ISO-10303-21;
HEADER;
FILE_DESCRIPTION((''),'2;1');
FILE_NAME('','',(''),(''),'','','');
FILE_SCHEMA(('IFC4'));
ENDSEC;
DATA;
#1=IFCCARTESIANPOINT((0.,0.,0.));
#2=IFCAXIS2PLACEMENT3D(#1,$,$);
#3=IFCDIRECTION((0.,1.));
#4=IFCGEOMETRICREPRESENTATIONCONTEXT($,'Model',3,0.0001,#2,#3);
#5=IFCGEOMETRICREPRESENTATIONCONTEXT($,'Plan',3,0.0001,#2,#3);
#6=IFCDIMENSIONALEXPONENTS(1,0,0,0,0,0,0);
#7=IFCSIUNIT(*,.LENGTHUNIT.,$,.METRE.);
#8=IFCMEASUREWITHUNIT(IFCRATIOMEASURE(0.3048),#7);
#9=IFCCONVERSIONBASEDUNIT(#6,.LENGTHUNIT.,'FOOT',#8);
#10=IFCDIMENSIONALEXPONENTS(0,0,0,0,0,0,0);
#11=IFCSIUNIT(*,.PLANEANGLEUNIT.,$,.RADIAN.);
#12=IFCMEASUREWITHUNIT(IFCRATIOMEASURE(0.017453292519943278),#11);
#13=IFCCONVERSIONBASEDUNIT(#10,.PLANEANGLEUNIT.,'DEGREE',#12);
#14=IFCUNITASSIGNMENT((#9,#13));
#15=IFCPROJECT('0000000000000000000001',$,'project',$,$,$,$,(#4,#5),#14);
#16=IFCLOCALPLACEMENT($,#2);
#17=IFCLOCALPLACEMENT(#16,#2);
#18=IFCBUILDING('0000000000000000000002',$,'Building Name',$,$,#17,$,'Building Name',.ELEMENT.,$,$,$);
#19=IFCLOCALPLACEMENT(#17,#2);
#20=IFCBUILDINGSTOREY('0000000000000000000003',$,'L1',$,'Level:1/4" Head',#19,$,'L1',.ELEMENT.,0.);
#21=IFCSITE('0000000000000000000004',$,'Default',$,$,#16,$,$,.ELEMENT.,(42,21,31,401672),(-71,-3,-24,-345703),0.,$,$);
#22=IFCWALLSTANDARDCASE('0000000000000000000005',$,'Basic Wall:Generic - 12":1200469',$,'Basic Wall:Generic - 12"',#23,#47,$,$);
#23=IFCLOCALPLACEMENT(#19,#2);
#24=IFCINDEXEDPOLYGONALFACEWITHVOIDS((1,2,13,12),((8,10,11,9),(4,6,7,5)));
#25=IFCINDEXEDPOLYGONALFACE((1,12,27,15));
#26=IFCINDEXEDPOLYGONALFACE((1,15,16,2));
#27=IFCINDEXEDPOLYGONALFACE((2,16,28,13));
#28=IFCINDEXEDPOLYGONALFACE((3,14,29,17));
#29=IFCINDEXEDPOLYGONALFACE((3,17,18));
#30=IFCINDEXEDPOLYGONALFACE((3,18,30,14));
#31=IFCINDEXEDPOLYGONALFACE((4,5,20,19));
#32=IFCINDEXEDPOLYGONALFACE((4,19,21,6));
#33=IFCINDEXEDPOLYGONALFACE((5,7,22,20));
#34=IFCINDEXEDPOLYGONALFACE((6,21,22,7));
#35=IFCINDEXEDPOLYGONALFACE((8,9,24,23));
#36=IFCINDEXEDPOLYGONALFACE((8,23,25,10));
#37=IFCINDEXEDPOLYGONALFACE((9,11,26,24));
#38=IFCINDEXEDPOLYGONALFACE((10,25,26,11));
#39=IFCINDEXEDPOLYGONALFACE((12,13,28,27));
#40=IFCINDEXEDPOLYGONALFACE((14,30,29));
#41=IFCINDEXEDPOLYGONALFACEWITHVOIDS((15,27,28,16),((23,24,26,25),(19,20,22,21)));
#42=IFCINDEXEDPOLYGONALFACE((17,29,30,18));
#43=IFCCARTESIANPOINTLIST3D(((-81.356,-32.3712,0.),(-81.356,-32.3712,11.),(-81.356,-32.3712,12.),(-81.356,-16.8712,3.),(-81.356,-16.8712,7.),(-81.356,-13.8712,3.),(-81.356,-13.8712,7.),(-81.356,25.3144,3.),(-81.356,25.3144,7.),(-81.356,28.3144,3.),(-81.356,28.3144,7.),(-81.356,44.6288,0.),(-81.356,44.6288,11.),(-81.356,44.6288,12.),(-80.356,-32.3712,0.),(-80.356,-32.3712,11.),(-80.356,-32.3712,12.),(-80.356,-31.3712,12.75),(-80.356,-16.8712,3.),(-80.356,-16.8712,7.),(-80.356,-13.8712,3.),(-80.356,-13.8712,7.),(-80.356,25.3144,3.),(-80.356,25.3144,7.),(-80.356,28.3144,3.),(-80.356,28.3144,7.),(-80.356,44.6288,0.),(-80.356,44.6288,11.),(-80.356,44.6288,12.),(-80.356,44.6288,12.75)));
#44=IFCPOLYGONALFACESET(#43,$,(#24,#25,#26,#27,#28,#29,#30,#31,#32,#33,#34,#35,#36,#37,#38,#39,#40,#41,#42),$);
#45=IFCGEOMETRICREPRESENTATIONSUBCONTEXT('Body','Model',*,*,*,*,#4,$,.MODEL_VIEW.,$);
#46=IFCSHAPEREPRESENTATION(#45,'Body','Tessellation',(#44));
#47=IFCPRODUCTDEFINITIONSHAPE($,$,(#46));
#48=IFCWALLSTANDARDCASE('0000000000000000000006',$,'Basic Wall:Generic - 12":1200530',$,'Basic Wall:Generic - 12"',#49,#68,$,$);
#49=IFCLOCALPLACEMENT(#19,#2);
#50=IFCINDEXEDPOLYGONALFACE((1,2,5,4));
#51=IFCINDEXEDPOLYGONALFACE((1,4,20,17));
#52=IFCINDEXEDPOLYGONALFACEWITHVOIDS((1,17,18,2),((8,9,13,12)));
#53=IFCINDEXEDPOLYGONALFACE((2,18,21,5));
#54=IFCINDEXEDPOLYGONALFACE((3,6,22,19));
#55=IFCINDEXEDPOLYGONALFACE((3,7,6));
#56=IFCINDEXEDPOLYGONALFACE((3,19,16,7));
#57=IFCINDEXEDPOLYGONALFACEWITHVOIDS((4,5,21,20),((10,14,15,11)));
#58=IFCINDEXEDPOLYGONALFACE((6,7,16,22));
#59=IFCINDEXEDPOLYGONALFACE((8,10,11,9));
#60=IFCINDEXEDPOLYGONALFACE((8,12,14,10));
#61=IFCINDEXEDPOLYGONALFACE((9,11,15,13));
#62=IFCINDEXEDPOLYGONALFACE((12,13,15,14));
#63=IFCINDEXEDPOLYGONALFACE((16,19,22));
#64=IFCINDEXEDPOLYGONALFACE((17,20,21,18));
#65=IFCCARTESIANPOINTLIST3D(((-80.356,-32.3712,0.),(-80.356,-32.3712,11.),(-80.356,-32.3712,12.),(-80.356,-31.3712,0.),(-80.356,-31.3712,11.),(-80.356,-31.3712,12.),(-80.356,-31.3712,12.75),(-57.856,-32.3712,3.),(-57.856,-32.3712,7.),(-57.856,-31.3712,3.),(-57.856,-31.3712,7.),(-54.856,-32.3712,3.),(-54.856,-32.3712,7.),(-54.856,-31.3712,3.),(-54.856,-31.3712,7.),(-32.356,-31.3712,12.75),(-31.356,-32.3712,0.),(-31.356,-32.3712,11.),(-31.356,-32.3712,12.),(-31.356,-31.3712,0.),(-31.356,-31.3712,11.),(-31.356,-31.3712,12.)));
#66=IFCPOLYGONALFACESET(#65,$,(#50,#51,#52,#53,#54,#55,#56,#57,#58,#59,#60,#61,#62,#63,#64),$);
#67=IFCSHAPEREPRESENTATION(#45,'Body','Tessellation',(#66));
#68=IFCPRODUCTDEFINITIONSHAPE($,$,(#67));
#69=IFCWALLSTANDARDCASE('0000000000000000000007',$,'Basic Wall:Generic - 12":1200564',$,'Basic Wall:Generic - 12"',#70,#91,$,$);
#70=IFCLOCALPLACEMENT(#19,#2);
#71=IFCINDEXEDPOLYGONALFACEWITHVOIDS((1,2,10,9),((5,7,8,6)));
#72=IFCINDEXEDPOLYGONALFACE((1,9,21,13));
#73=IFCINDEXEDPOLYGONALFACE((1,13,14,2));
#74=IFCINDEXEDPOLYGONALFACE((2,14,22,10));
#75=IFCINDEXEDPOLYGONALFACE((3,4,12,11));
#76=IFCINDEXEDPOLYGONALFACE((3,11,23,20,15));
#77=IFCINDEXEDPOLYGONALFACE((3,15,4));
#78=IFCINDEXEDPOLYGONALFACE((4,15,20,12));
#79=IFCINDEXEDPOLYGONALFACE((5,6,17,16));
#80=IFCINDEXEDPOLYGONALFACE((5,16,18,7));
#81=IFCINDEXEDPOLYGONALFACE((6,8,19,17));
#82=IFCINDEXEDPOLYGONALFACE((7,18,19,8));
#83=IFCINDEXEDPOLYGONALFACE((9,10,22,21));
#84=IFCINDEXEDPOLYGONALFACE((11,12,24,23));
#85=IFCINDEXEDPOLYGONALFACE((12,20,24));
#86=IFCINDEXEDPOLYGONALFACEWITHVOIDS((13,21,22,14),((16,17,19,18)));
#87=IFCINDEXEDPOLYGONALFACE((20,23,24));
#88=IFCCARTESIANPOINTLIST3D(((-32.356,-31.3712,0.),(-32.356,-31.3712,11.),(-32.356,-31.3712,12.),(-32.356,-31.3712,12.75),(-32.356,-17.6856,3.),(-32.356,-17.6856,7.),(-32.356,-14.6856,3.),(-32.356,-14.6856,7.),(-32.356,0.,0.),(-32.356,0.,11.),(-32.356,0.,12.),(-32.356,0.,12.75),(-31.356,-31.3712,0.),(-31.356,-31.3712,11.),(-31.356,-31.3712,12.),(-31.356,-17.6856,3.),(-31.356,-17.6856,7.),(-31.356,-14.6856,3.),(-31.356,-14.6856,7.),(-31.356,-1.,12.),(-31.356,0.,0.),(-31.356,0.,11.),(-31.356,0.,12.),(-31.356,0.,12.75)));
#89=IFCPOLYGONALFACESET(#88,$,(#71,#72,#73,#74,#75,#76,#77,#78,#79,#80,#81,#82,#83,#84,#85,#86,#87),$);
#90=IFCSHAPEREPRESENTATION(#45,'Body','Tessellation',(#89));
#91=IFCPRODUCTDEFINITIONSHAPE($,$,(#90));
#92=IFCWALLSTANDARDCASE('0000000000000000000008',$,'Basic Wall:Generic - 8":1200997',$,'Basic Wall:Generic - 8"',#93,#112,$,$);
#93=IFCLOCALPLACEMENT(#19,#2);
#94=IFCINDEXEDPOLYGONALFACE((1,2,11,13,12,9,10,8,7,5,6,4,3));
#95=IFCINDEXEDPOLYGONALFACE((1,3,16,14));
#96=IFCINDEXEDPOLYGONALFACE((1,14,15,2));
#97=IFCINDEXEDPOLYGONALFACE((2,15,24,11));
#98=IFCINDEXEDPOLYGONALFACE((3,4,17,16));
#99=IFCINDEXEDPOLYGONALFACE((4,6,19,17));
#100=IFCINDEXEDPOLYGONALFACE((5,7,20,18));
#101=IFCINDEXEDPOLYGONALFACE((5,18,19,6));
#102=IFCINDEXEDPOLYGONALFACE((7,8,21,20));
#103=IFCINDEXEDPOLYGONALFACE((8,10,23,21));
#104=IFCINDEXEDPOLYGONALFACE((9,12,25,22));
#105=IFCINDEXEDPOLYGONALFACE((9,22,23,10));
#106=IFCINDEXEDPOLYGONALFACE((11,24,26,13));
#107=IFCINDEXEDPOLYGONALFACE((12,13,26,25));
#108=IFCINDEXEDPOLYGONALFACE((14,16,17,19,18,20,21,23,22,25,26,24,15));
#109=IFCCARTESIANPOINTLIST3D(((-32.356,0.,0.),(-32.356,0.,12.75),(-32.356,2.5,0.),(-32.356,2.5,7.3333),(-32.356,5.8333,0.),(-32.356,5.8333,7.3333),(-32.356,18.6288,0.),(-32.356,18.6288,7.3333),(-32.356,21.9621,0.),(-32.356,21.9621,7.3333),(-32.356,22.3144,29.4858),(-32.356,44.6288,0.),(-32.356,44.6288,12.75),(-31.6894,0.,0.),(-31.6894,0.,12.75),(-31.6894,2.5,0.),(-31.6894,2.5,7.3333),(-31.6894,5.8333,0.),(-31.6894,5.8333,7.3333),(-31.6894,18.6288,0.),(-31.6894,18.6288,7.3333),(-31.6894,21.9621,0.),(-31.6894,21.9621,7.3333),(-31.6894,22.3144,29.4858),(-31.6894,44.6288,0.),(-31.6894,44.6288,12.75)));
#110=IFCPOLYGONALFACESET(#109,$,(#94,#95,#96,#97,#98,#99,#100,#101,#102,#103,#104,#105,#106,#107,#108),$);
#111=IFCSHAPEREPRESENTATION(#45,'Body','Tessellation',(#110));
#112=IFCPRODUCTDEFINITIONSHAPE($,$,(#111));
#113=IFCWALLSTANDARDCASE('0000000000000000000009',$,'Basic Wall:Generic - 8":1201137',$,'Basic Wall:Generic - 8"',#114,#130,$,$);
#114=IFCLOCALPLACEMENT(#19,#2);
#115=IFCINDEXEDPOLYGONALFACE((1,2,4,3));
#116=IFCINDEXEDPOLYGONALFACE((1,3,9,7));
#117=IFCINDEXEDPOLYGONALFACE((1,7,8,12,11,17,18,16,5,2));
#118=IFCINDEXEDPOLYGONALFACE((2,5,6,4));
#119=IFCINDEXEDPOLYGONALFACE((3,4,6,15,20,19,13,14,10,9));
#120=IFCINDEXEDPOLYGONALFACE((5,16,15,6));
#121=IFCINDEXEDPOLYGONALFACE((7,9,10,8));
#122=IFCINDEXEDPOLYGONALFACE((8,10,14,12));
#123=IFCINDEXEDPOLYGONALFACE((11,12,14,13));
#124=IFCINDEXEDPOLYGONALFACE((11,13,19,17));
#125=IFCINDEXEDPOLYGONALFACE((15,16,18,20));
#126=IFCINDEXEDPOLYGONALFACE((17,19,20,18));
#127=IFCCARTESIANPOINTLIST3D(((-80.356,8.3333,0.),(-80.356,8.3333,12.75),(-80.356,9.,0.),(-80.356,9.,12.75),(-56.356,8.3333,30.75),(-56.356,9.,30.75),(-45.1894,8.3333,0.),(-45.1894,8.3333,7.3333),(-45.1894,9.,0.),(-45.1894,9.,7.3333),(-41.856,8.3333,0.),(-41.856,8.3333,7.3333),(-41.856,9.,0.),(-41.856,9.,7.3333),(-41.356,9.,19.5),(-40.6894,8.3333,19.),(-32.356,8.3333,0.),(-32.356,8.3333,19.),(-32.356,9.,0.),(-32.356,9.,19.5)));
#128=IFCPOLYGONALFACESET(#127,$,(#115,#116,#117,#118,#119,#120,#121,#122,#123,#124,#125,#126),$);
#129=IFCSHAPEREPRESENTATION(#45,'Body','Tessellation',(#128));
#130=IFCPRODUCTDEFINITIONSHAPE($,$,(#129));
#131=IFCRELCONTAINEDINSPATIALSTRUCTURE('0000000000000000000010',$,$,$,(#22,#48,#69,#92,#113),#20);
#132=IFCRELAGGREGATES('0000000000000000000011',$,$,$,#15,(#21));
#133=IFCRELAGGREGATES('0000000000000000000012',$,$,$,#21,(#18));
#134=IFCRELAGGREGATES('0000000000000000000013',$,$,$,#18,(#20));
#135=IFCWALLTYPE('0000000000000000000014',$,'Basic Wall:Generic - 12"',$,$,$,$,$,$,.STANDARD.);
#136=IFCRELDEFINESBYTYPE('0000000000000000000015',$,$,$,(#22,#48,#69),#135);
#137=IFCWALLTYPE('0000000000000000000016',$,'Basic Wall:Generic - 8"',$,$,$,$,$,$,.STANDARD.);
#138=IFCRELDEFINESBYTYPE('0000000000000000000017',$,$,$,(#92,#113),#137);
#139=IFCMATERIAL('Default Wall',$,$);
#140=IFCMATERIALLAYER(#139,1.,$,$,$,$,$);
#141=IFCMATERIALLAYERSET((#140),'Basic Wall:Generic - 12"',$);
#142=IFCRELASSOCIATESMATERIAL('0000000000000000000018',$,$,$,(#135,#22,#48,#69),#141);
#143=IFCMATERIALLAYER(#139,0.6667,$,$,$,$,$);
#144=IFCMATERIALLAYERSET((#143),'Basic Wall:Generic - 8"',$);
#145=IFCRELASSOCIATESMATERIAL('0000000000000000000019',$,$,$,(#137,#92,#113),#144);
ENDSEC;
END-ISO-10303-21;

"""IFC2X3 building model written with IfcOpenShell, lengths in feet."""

from ifc_helpers import new_model, entity, si_unit, converted_unit, direction, frame, frame_2d, origin, place, context, subcontext, project, spatial, polyline, rectangle, extrude, clip, bounded_halfspace, material, layer, layer_set, layer_usage, type_object, element, save


model = new_model("IFC2X3")

# Units and contexts
model_context = context("Model", 3, precision=0.0001, world=origin(), true_north=direction((0.0, 1.0)))
plan_context = context("Plan", 3, precision=0.0001, world=origin(), true_north=direction((0.0, 1.0)))
body_context = subcontext(model_context, "Body", "Model", "MODEL_VIEW")
ifc_project = project(units=[converted_unit("LENGTHUNIT", "FOOT", entity("IfcRatioMeasure", 0.3048), si_unit("LENGTHUNIT", "METRE"), dimensions=[1, 0, 0, 0, 0, 0, 0]), converted_unit("PLANEANGLEUNIT", "DEGREE", entity("IfcRatioMeasure", 0.017453292519943278), si_unit("PLANEANGLEUNIT", "RADIAN"), dimensions=[0, 0, 0, 0, 0, 0, 0])], contexts=[model_context, plan_context])

# Site, building, storey
site_placement = place(None, origin())
site = spatial("IfcSite", under=ifc_project, at=site_placement, Name="Default", CompositionType="ELEMENT", RefLatitude=(42, 21, 31, 401672), RefLongitude=(-71, -3, -24, -345703), RefElevation=0.0)
building_placement = place(site_placement, origin())
building = spatial("IfcBuilding", under=site, at=building_placement, Name="Building Name", LongName="Building Name", CompositionType="ELEMENT")
storey_placement = place(building_placement, origin())
storey = spatial("IfcBuildingStorey", under=building, at=storey_placement, Name="L1", ObjectType="Level:1/4\" Head", LongName="L1", CompositionType="ELEMENT", Elevation=0.0)

# Walls, openings
ifc_material_1 = material(Name="Default Wall")
ifc_layer_1 = layer(ifc_material_1, 1.0)
ifc_layer_set_1 = layer_set([ifc_layer_1], Name="Basic Wall:Generic - 12\"")
ifc_layer_usage_1 = layer_usage(ifc_layer_set_1, "AXIS2", "NEGATIVE", 0.5)
wall_type_1 = type_object("IfcWallType", Name="Basic Wall:Generic - 12\"", PredefinedType="STANDARD", material=ifc_layer_set_1)
wall_1_placement = place(storey_placement, frame((-80.856, 44.6288, 0.0), z_axis=(0.0, 0.0, 1.0), x_axis=(0.0, -1.0, 0.0)))
wall_1 = element("IfcWallStandardCase", 1, at=wall_1_placement, inside=storey, type_object=wall_type_1, material=ifc_layer_usage_1, Name="Basic Wall:Generic - 12\":1200469", ObjectType="Basic Wall:Generic - 12\"", context=body_context, shape_type="Clipping", body=[
    clip(clip(extrude(rectangle(XDim=77.0, YDim=1.0, at=frame_2d((38.5, 0.0), x_axis=(-1.0, 0.0))), origin(), (0.0, 0.0, 1.0), 12.75), bounded_halfspace(frame((0.0, 0.5, 12.75), z_axis=(0.0, -0.6, 0.8), x_axis=(1.0, 0.0, 0.0)), False, frame((0.0, 0.5, 12.75)), polyline([(0.0, 0.0), (0.0, -1.0), (77.0, -1.0), (76.0, 0.0), (36.2955, 0.0), (35.6288, 0.0), (0.0, 0.0)]))), bounded_halfspace(frame((77.0, 0.5, 12.0), z_axis=(0.6, 0.0, 0.8), x_axis=(0.0, 1.0, 0.0)), False, frame((77.0, 0.5, 12.0)), polyline([(0.0, 0.0), (-1.0, 0.0), (0.0, -1.0), (0.0, 0.0)]))),
])
opening_1_placement = place(storey_placement, frame((-80.856, 44.6288, 0.0), z_axis=(0.0, 0.0, 1.0), x_axis=(0.0, -1.0, 0.0)))
element("IfcOpeningElement", 2, at=opening_1_placement, cuts=wall_1, ObjectType="Opening", context=body_context, shape_type="SweptSolid", body=[
    extrude(rectangle(XDim=77.0, YDim=1.0, at=frame_2d((-7.5, -0.1), x_axis=(1.0, 0.0))), frame((46.0, 0.1, 11.0)), (0.0, 0.0, 1.0), 1.0),
])
opening_2_placement = place(wall_1_placement, frame((19.3144, 0.5, 3.0)))
element("IfcOpeningElement", 3, at=opening_2_placement, cuts=wall_1, ObjectType="Opening", context=body_context, shape_type="SweptSolid", body=[
    extrude(rectangle(XDim=4.0, YDim=3.0, at=frame_2d((2.0, 1.5), x_axis=(-1.0, 0.0))), frame((0.0, 0.0, 0.0), z_axis=(0.0, -1.0, 0.0), x_axis=(0.0, 0.0, 1.0)), (0.0, 0.0, 1.0), 1.0),
])
opening_3_placement = place(wall_1_placement, frame((61.5, 0.5, 3.0)))
element("IfcOpeningElement", 4, at=opening_3_placement, cuts=wall_1, ObjectType="Opening", context=body_context, shape_type="SweptSolid", body=[
    extrude(rectangle(XDim=4.0, YDim=3.0, at=frame_2d((2.0, 1.5), x_axis=(-1.0, 0.0))), frame((0.0, 0.0, 0.0), z_axis=(0.0, -1.0, 0.0), x_axis=(0.0, 0.0, 1.0)), (0.0, 0.0, 1.0), 1.0),
])
wall_2_placement = place(storey_placement, frame((-80.356, -31.8712, 0.0)))
wall_2 = element("IfcWallStandardCase", 5, at=wall_2_placement, inside=storey, type_object=wall_type_1, material=ifc_layer_usage_1, Name="Basic Wall:Generic - 12\":1200530", ObjectType="Basic Wall:Generic - 12\"", context=body_context, shape_type="Clipping", body=[
    clip(clip(extrude(rectangle(XDim=49.0, YDim=1.0, at=frame_2d((24.5, 0.0), x_axis=(-1.0, 0.0))), origin(), (0.0, 0.0, 1.0), 12.75), bounded_halfspace(frame((0.0, 0.5, 12.75), z_axis=(0.0, -0.6, 0.8), x_axis=(1.0, 0.0, 0.0)), False, frame((0.0, 0.5, 12.75)), polyline([(0.0, 0.0), (0.0, -1.0), (49.0, -1.0), (48.0, 0.0), (0.0, 0.0)]))), bounded_halfspace(frame((49.0, 0.5, 12.0), z_axis=(0.6, 0.0, 0.8), x_axis=(0.0, 1.0, 0.0)), False, frame((49.0, 0.5, 12.0)), polyline([(0.0, 0.0), (-1.0, 0.0), (0.0, -1.0), (0.0, 0.0)]))),
])
opening_4_placement = place(storey_placement, frame((-80.356, -31.8712, 0.0)))
element("IfcOpeningElement", 6, at=opening_4_placement, cuts=wall_2, ObjectType="Opening", context=body_context, shape_type="SweptSolid", body=[
    extrude(rectangle(XDim=49.0, YDim=1.0, at=frame_2d((-4.7, -0.1), x_axis=(1.0, 0.0))), frame((29.2, 0.1, 11.0)), (0.0, 0.0, 1.0), 1.0),
])
opening_5_placement = place(wall_2_placement, frame((22.5, -0.5, 3.0)))
element("IfcOpeningElement", 7, at=opening_5_placement, cuts=wall_2, ObjectType="Opening", context=body_context, shape_type="SweptSolid", body=[
    extrude(rectangle(XDim=4.0, YDim=3.0, at=frame_2d((2.0, 1.5), x_axis=(-1.0, 0.0))), frame((0.0, 0.0, 0.0), z_axis=(0.0, 1.0, 0.0), x_axis=(0.0, 0.0, 1.0)), (0.0, 0.0, 1.0), 1.0),
])
wall_3_placement = place(storey_placement, frame((-31.856, -31.3712, 0.0), z_axis=(0.0, 0.0, 1.0), x_axis=(0.0, 1.0, 0.0)))
wall_3 = element("IfcWallStandardCase", 8, at=wall_3_placement, inside=storey, type_object=wall_type_1, material=ifc_layer_usage_1, Name="Basic Wall:Generic - 12\":1200564", ObjectType="Basic Wall:Generic - 12\"", context=body_context, shape_type="Clipping", body=[
    clip(clip(extrude(rectangle(XDim=31.3712, YDim=1.0, at=frame_2d((15.6856, 0.0), x_axis=(-1.0, 0.0))), origin(), (0.0, 0.0, 1.0), 12.75), bounded_halfspace(frame((31.3712, 0.5, 12.75), z_axis=(0.0, -0.6, 0.8), x_axis=(1.0, 0.0, 0.0)), False, frame((31.3712, 0.5, 12.75)), polyline([(0.0, 0.0), (-31.3712, 0.0), (-31.3712, -1.0), (-1.0, -1.0), (0.0, 0.0)]))), bounded_halfspace(frame((31.3712, -0.5, 12.75), z_axis=(-0.6, 0.0, 0.8), x_axis=(0.0, -1.0, 0.0)), False, frame((31.3712, -0.5, 12.75)), polyline([(0.0, 0.0), (0.0, 0.3333), (0.0, 1.0), (-1.0, 0.0), (0.0, 0.0)]))),
])
opening_6_placement = place(storey_placement, frame((-31.856, -31.3712, 0.0), z_axis=(0.0, 0.0, 1.0), x_axis=(0.0, 1.0, 0.0)))
element("IfcOpeningElement", 9, at=opening_6_placement, cuts=wall_3, ObjectType="Opening", context=body_context, shape_type="SweptSolid", body=[
    extrude(rectangle(XDim=31.3712, YDim=1.0, at=frame_2d((-2.9371, 0.1), x_axis=(1.0, 0.0))), frame((18.6227, -0.1, 11.0)), (0.0, 0.0, 1.0), 1.0),
])
opening_7_placement = place(wall_3_placement, frame((16.6856, 0.5, 3.0)))
element("IfcOpeningElement", 10, at=opening_7_placement, cuts=wall_3, ObjectType="Opening", context=body_context, shape_type="SweptSolid", body=[
    extrude(rectangle(XDim=4.0, YDim=3.0, at=frame_2d((2.0, 1.5), x_axis=(-1.0, 0.0))), frame((0.0, 0.0, 0.0), z_axis=(0.0, -1.0, 0.0), x_axis=(0.0, 0.0, 1.0)), (0.0, 0.0, 1.0), 1.0),
])
ifc_layer_2 = layer(ifc_material_1, 0.6667)
ifc_layer_set_2 = layer_set([ifc_layer_2], Name="Basic Wall:Generic - 8\"")
ifc_layer_usage_2 = layer_usage(ifc_layer_set_2, "AXIS2", "NEGATIVE", 0.3333)
wall_type_2 = type_object("IfcWallType", Name="Basic Wall:Generic - 8\"", PredefinedType="STANDARD", material=ifc_layer_set_2)
wall_4_placement = place(storey_placement, frame((-32.0227, 0.0, 0.0), z_axis=(0.0, 0.0, 1.0), x_axis=(0.0, 1.0, 0.0)))
wall_4 = element("IfcWallStandardCase", 11, at=wall_4_placement, inside=storey, type_object=wall_type_2, material=ifc_layer_usage_2, Name="Basic Wall:Generic - 8\":1200997", ObjectType="Basic Wall:Generic - 8\"", context=body_context, shape_type="Clipping", body=[
    clip(clip(extrude(rectangle(XDim=44.6288, YDim=0.6667, at=frame_2d((22.3144, 0.0), x_axis=(-1.0, 0.0))), origin(), (0.0, 0.0, 1.0), 29.4858), bounded_halfspace(frame((0.0, 0.3333, 12.75), z_axis=(-0.6, 0.0, 0.8), x_axis=(0.0, -1.0, 0.0)), False, frame((0.0, 0.3333, 12.75)), polyline([(0.0, 0.0), (0.0, -0.6667), (22.3144, -0.6667), (22.3144, 0.0), (9.0, 0.0), (8.3333, 0.0), (0.0, 0.0)]))), bounded_halfspace(frame((44.6288, -0.3333, 12.75), z_axis=(0.6, 0.0, 0.8), x_axis=(0.0, 1.0, 0.0)), False, frame((44.6288, -0.3333, 12.75)), polyline([(0.0, 0.0), (0.0, 0.6667), (-22.3144, 0.6667), (-22.3144, 0.0), (-17.6667, 0.0), (-17.0, 0.0), (0.0, 0.0)]))),
])
opening_8_placement = place(wall_4_placement, frame((18.6288, -0.3333, 0.0)))
element("IfcOpeningElement", 12, at=opening_8_placement, cuts=wall_4, ObjectType="Opening", context=body_context, shape_type="SweptSolid", body=[
    extrude(rectangle(XDim=7.3333, YDim=3.3333, at=frame_2d((3.6667, 1.6667), x_axis=(1.0, 0.0))), frame((0.0, 0.0, 0.0), z_axis=(0.0, 1.0, 0.0), x_axis=(0.0, 0.0, 1.0)), (0.0, 0.0, 1.0), 0.6667),
])
opening_9_placement = place(wall_4_placement, frame((2.5, -0.3333, 0.0)))
element("IfcOpeningElement", 13, at=opening_9_placement, cuts=wall_4, ObjectType="Opening", context=body_context, shape_type="SweptSolid", body=[
    extrude(rectangle(XDim=7.3333, YDim=3.3333, at=frame_2d((3.6667, 1.6667), x_axis=(1.0, 0.0))), frame((0.0, 0.0, 0.0), z_axis=(0.0, 1.0, 0.0), x_axis=(0.0, 0.0, 1.0)), (0.0, 0.0, 1.0), 0.6667),
])

# Wall, opening
wall_5_placement = place(storey_placement, frame((-80.356, 8.6667, 0.0)))
wall_5 = element("IfcWallStandardCase", 14, at=wall_5_placement, inside=storey, type_object=wall_type_2, material=ifc_layer_usage_2, Name="Basic Wall:Generic - 8\":1201137", ObjectType="Basic Wall:Generic - 8\"", context=body_context, shape_type="Clipping", body=[
    clip(clip(clip(extrude(rectangle(XDim=48.0, YDim=0.6667, at=frame_2d((24.0, 0.0), x_axis=(-1.0, 0.0))), origin(), (0.0, 0.0, 1.0), 30.75), bounded_halfspace(frame((0.0, 0.3333, 12.75), z_axis=(-0.6, 0.0, 0.8), x_axis=(0.0, -1.0, 0.0)), False, frame((0.0, 0.3333, 12.75)), polyline([(0.0, 0.0), (0.0, -0.6667), (24.0, -0.6667), (24.0, 0.0), (0.0, 0.0)]))), bounded_halfspace(frame((24.0, -0.3333, 30.75), z_axis=(0.6, 0.0, 0.8), x_axis=(0.0, 1.0, 0.0)), False, frame((24.0, -0.3333, 30.75)), polyline([(0.0, 0.0), (15.6667, 0.0), (15.0, 0.6667), (0.0, 0.6667), (0.0, 0.0)]))), bounded_halfspace(frame((48.0, -0.3333, 19.0), z_axis=(0.0, -0.6, 0.8), x_axis=(1.0, 0.0, 0.0)), False, frame((48.0, -0.3333, 19.0)), polyline([(0.0, 0.0), (0.0, 0.6667), (-9.0, 0.6667), (-8.3333, 0.0), (0.0, 0.0)]))),
])
opening_10_placement = place(wall_5_placement, frame((38.5, 0.3333, 0.0)))
element("IfcOpeningElement", 15, at=opening_10_placement, cuts=wall_5, ObjectType="Opening", context=body_context, shape_type="SweptSolid", body=[
    extrude(rectangle(XDim=7.3333, YDim=3.3333, at=frame_2d((3.6667, 1.6667), x_axis=(1.0, 0.0))), frame((0.0, 0.0, 0.0), z_axis=(0.0, -1.0, 0.0), x_axis=(0.0, 0.0, 1.0)), (0.0, 0.0, 1.0), 0.6667),
])

save(model, "model.ifc")
